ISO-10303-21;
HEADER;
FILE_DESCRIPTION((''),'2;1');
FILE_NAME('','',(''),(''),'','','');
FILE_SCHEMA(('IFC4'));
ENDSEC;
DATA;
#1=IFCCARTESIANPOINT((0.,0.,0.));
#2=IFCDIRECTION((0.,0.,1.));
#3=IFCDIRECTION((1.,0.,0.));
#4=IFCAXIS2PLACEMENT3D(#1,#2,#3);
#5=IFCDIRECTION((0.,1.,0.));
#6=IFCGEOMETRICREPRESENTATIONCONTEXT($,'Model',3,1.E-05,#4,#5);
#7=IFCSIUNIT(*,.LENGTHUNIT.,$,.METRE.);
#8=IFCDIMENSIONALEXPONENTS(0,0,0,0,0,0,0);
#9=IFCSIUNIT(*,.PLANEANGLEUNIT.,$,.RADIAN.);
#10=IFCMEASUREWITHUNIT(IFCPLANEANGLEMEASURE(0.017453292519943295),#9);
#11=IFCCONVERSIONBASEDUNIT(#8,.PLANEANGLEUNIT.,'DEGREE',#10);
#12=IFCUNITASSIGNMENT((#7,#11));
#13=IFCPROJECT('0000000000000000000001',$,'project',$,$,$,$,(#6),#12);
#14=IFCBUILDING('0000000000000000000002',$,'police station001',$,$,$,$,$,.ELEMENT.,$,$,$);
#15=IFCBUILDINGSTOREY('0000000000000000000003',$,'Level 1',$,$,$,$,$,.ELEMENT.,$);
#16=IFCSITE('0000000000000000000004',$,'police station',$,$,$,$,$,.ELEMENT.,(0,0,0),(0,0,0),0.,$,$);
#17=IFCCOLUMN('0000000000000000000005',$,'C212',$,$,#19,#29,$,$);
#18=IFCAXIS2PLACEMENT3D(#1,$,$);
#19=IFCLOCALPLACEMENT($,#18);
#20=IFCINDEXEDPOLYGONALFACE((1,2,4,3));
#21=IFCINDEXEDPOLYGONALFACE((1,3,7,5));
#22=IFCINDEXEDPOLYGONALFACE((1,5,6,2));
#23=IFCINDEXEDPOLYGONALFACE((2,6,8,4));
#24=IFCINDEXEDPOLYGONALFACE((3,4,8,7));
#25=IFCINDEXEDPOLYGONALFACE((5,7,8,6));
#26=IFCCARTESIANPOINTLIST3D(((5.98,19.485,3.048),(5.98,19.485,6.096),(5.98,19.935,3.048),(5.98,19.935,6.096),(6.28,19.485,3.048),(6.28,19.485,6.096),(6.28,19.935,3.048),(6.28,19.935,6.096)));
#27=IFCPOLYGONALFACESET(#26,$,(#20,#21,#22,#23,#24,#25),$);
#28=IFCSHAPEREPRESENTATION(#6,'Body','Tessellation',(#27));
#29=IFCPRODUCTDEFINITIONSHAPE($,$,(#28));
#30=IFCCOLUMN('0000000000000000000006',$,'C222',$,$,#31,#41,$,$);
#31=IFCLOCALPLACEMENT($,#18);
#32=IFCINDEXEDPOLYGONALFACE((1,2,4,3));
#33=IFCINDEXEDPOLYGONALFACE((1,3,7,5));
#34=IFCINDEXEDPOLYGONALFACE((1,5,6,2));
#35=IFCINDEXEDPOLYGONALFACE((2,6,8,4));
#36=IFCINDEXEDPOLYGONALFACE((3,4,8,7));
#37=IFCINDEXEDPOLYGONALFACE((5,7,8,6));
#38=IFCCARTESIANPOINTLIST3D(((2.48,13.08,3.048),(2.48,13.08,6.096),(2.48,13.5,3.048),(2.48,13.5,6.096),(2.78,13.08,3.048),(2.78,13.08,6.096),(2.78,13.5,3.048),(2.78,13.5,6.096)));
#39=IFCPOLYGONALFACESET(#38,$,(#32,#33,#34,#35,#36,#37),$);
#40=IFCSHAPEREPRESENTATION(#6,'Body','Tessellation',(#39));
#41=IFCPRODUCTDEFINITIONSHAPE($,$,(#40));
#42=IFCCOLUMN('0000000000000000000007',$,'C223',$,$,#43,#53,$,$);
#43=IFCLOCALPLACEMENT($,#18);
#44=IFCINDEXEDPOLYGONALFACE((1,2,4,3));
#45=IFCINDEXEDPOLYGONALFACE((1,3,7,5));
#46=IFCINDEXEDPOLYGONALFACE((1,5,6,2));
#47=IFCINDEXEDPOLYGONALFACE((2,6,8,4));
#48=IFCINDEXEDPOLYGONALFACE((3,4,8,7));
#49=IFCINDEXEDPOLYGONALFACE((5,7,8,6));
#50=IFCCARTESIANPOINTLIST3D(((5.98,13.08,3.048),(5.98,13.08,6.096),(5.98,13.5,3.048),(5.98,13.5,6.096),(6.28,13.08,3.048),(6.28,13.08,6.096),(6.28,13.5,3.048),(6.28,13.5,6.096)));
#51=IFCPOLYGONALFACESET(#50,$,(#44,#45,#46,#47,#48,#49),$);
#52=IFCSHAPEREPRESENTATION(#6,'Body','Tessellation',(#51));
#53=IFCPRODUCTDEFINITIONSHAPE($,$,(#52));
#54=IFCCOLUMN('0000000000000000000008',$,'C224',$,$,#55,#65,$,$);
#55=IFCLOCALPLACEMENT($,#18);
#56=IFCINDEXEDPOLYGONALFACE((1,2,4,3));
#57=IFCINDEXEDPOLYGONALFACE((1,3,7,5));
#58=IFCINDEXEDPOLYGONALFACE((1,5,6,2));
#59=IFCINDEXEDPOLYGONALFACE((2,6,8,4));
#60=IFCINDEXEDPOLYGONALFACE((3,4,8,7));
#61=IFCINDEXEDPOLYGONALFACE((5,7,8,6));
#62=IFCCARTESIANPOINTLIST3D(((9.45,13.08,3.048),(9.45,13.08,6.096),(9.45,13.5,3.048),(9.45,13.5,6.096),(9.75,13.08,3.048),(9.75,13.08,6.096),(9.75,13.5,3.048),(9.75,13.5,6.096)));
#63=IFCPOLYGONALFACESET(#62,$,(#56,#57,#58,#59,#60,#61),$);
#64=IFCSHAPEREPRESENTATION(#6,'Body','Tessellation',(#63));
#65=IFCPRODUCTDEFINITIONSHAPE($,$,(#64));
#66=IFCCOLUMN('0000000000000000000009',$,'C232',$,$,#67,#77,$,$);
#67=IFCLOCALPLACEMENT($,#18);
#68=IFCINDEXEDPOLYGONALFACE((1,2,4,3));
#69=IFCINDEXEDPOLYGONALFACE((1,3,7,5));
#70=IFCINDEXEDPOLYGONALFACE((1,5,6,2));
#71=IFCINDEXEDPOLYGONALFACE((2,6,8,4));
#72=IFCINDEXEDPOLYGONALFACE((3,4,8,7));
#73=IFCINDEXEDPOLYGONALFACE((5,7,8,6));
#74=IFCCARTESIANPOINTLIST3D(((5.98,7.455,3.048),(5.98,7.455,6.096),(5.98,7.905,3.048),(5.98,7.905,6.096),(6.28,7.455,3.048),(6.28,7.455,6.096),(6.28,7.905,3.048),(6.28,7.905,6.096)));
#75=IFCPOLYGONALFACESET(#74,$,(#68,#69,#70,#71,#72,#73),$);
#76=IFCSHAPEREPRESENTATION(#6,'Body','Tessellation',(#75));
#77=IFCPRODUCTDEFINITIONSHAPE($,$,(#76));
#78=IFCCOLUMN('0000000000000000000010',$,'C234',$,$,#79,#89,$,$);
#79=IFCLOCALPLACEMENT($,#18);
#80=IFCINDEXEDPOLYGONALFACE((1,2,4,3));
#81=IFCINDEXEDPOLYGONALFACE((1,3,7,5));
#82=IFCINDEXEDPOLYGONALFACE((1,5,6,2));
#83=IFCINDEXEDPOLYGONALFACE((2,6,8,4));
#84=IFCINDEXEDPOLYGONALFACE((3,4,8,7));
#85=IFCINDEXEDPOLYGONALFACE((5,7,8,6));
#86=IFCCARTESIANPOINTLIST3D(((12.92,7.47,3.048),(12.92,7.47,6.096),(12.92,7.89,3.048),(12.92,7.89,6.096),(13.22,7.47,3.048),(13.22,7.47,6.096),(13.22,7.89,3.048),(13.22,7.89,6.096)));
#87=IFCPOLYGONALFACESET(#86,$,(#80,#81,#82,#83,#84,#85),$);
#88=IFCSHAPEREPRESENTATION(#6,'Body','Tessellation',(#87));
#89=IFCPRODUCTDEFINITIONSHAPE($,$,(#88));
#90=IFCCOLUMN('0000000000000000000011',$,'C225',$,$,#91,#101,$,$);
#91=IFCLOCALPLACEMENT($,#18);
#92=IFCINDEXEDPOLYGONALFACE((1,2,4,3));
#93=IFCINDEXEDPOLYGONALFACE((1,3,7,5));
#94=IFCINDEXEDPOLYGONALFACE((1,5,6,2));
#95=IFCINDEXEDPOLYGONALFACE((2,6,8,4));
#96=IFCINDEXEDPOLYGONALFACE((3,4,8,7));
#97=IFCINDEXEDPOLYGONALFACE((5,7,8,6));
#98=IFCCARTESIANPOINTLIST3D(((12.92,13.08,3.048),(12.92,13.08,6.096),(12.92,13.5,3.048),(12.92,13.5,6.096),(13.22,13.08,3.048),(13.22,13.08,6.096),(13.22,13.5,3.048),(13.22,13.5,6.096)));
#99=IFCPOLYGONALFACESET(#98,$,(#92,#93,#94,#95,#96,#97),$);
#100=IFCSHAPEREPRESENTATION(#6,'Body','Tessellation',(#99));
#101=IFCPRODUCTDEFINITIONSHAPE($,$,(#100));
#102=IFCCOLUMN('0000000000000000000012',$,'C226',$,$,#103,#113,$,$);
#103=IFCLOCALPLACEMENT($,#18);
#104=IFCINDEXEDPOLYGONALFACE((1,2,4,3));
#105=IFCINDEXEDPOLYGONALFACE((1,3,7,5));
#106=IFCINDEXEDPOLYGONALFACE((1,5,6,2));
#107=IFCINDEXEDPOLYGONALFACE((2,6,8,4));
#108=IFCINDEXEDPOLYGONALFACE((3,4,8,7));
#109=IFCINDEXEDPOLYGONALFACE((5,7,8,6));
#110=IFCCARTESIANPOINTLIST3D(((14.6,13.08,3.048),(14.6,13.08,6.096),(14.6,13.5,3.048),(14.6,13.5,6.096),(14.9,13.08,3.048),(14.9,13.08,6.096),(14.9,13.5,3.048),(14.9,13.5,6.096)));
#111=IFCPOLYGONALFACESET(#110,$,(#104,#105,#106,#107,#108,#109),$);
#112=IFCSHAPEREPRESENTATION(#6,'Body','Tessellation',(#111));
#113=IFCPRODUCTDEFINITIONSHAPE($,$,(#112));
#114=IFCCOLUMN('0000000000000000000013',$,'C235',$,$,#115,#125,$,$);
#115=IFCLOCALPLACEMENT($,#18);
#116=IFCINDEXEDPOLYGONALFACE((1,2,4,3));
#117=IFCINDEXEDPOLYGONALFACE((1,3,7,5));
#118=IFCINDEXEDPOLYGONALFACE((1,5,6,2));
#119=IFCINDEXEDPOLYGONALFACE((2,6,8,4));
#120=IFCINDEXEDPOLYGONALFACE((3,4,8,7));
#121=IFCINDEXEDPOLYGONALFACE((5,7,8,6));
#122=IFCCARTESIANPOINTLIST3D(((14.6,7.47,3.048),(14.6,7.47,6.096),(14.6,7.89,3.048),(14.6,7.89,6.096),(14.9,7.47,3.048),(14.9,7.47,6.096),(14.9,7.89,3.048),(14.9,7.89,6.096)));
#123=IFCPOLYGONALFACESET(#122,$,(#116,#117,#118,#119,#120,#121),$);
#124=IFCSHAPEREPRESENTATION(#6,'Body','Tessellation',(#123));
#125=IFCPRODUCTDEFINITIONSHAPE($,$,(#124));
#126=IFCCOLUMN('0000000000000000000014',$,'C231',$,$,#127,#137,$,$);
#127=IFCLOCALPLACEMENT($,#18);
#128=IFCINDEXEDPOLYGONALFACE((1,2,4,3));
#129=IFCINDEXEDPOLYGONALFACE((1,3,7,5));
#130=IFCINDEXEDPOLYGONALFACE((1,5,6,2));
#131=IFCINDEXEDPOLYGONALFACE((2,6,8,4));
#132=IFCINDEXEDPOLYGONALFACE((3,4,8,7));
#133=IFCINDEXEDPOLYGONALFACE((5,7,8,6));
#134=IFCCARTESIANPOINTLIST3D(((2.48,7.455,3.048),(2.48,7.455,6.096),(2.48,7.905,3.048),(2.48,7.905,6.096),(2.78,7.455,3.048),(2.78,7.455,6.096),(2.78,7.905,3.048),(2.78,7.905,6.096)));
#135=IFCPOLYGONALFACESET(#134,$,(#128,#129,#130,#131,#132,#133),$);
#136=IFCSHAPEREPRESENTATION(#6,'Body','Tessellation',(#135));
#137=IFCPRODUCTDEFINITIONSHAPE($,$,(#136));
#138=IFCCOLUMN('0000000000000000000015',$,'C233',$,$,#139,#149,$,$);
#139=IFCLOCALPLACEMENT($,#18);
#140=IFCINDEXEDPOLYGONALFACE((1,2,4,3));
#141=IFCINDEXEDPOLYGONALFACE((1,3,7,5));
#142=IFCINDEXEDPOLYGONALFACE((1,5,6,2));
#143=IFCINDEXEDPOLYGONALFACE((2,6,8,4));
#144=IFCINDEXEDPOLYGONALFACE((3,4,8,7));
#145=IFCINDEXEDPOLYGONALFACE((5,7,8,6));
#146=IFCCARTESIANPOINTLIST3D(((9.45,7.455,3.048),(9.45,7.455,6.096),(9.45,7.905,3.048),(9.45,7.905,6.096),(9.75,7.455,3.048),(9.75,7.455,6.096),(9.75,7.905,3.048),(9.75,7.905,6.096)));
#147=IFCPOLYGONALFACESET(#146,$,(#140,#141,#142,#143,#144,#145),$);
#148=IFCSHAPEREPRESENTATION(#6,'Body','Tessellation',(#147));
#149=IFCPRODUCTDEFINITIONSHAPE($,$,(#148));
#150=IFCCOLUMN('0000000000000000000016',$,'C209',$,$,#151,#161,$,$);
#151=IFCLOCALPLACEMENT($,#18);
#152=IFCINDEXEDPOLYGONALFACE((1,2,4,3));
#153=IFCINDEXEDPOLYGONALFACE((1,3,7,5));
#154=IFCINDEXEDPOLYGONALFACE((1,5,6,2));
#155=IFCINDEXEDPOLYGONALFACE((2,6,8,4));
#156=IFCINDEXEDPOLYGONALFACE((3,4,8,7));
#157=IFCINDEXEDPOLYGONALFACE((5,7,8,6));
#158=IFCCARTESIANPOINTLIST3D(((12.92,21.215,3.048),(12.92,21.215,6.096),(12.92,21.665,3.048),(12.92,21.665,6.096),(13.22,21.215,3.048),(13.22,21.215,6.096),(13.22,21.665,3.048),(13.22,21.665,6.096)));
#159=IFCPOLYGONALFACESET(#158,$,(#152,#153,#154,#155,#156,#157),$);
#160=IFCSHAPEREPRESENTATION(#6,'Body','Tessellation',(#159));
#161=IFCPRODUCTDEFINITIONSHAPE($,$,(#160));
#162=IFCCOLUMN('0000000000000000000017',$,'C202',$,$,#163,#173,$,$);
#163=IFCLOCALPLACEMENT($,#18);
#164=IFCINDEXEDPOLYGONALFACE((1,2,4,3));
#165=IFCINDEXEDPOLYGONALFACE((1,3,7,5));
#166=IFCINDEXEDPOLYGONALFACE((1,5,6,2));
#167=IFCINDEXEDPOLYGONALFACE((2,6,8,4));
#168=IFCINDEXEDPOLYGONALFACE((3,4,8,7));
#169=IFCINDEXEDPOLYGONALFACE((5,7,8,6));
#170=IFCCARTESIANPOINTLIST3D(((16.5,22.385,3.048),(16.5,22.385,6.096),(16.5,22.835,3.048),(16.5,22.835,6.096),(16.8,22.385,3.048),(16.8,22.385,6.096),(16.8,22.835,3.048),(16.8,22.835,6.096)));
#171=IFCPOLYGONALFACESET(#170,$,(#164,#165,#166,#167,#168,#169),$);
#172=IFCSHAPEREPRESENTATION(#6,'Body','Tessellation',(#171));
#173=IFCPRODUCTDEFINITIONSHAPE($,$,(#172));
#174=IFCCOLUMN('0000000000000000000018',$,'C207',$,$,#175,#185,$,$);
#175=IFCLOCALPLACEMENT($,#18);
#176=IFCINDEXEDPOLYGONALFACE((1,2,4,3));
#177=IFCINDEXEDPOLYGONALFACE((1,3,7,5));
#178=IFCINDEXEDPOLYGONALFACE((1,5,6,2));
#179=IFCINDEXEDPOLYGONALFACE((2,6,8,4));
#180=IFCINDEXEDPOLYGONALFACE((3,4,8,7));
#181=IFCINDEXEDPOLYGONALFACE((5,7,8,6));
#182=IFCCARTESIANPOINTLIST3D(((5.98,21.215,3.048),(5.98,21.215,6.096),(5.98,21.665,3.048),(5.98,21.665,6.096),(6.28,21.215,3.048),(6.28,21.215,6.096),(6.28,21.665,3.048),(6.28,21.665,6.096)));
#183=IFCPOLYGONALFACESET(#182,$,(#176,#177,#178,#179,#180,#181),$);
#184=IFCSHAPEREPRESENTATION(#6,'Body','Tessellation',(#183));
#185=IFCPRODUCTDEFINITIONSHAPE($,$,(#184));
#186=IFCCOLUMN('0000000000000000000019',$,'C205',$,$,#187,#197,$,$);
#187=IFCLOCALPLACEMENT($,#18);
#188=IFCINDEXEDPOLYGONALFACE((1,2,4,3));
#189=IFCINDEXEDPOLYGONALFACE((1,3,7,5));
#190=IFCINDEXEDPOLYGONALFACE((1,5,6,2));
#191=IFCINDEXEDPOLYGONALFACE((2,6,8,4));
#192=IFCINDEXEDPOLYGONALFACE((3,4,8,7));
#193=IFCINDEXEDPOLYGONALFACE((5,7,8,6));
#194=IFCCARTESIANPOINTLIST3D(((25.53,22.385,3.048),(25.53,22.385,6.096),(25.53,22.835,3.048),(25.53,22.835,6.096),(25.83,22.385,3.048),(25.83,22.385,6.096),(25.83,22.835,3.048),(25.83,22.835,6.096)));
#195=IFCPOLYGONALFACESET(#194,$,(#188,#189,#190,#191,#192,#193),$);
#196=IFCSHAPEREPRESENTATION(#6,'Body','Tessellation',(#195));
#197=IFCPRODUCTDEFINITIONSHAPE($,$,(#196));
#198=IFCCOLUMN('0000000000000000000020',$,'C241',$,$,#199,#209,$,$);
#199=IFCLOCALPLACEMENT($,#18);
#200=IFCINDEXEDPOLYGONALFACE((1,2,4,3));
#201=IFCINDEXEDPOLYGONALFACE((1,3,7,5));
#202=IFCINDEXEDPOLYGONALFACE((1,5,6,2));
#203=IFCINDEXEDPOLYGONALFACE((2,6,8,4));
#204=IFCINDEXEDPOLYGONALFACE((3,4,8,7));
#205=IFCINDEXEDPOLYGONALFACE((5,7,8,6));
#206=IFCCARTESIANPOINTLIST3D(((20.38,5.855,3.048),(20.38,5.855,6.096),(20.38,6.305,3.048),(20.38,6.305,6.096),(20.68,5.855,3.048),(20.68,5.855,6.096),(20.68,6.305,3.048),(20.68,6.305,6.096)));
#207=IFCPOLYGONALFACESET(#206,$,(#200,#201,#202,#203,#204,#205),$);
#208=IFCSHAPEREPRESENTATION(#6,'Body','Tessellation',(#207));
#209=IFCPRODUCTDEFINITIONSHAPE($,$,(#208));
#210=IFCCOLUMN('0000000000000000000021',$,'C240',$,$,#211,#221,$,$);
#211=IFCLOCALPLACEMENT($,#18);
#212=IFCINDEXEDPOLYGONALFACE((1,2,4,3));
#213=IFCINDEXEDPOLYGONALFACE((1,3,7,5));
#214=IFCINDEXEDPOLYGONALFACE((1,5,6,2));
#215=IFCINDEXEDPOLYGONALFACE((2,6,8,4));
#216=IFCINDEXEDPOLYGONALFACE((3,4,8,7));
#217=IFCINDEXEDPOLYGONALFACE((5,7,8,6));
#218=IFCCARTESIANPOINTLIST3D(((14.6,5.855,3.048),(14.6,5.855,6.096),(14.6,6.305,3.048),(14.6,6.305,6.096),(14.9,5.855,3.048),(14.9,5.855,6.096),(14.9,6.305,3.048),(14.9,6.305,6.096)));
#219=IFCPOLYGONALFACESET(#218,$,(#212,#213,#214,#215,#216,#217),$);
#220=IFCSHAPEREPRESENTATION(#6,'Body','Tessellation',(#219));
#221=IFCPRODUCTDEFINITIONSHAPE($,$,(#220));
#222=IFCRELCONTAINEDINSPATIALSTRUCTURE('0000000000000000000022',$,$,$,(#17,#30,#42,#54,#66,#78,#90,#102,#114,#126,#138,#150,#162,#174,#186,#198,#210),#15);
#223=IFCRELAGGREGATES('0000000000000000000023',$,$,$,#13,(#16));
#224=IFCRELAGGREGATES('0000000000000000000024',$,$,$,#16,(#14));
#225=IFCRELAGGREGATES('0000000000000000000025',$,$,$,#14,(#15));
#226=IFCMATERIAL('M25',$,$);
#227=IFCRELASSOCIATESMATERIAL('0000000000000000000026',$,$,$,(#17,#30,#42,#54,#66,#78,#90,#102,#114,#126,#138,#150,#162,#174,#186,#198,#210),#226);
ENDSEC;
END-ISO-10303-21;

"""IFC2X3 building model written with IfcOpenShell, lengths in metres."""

from ifc_helpers import new_model, entity, si_unit, converted_unit, direction, frame, frame_2d, origin_with_axes, place, context, project, spatial, rectangle, extrude, material, element, save


model = new_model("IFC2X3")

# Units and contexts
model_context = context("Model", 3, precision=1e-05, world=origin_with_axes(), true_north=direction((0.0, 1.0, 0.0)))
ifc_project = project(units=[si_unit("LENGTHUNIT", "METRE"), converted_unit("PLANEANGLEUNIT", "DEGREE", entity("IfcPlaneAngleMeasure", 0.017453292519943295), si_unit("PLANEANGLEUNIT", "RADIAN"), dimensions=[0, 0, 0, 0, 0, 0, 0])], contexts=[model_context])

# Site, building, storey
site = spatial("IfcSite", under=ifc_project, Name="police station", CompositionType="ELEMENT", RefLatitude=(0, 0, 0), RefLongitude=(0, 0, 0), RefElevation=0.0)
building = spatial("IfcBuilding", under=site, Name="police station001", CompositionType="ELEMENT")
storey = spatial("IfcBuildingStorey", under=building, Name="Level 1", CompositionType="ELEMENT")

# Columns
ifc_material = material(Name="M25")
placement = place(None, origin_with_axes())
element("IfcColumn", 1, at=placement, inside=storey, material=ifc_material, Name="C212", context=model_context, shape_type="SweptSolid", body=[
    extrude(rectangle(XDim=0.3, YDim=0.45, at=frame_2d((0.0, 0.0), x_axis=(1.0, 0.0, 0.0))), frame((6.13, 19.71, 3.048), z_axis=(0.0, 0.0, 1.0), x_axis=(1.0, 0.0, 0.0)), (0.0, 0.0, 1.0), 3.048),
])
element("IfcColumn", 2, at=placement, inside=storey, material=ifc_material, Name="C222", context=model_context, shape_type="SweptSolid", body=[
    extrude(rectangle(XDim=0.3, YDim=0.42, at=frame_2d((0.0, 0.0), x_axis=(1.0, 0.0, 0.0))), frame((2.63, 13.29, 3.048), z_axis=(0.0, 0.0, 1.0), x_axis=(1.0, 0.0, 0.0)), (0.0, 0.0, 1.0), 3.048),
])
element("IfcColumn", 3, at=placement, inside=storey, material=ifc_material, Name="C223", context=model_context, shape_type="SweptSolid", body=[
    extrude(rectangle(XDim=0.3, YDim=0.42, at=frame_2d((0.0, 0.0), x_axis=(1.0, 0.0, 0.0))), frame((6.13, 13.29, 3.048), z_axis=(0.0, 0.0, 1.0), x_axis=(1.0, 0.0, 0.0)), (0.0, 0.0, 1.0), 3.048),
])
element("IfcColumn", 4, at=placement, inside=storey, material=ifc_material, Name="C224", context=model_context, shape_type="SweptSolid", body=[
    extrude(rectangle(XDim=0.3, YDim=0.42, at=frame_2d((0.0, 0.0), x_axis=(1.0, 0.0, 0.0))), frame((9.6, 13.29, 3.048), z_axis=(0.0, 0.0, 1.0), x_axis=(1.0, 0.0, 0.0)), (0.0, 0.0, 1.0), 3.048),
])
element("IfcColumn", 5, at=placement, inside=storey, material=ifc_material, Name="C232", context=model_context, shape_type="SweptSolid", body=[
    extrude(rectangle(XDim=0.3, YDim=0.45, at=frame_2d((0.0, 0.0), x_axis=(1.0, 0.0, 0.0))), frame((6.13, 7.68, 3.048), z_axis=(0.0, 0.0, 1.0), x_axis=(1.0, 0.0, 0.0)), (0.0, 0.0, 1.0), 3.048),
])
element("IfcColumn", 6, at=placement, inside=storey, material=ifc_material, Name="C234", context=model_context, shape_type="SweptSolid", body=[
    extrude(rectangle(XDim=0.3, YDim=0.42, at=frame_2d((0.0, 0.0), x_axis=(1.0, 0.0, 0.0))), frame((13.07, 7.68, 3.048), z_axis=(0.0, 0.0, 1.0), x_axis=(1.0, 0.0, 0.0)), (0.0, 0.0, 1.0), 3.048),
])
element("IfcColumn", 7, at=placement, inside=storey, material=ifc_material, Name="C225", context=model_context, shape_type="SweptSolid", body=[
    extrude(rectangle(XDim=0.3, YDim=0.42, at=frame_2d((0.0, 0.0), x_axis=(1.0, 0.0, 0.0))), frame((13.07, 13.29, 3.048), z_axis=(0.0, 0.0, 1.0), x_axis=(1.0, 0.0, 0.0)), (0.0, 0.0, 1.0), 3.048),
])
element("IfcColumn", 8, at=placement, inside=storey, material=ifc_material, Name="C226", context=model_context, shape_type="SweptSolid", body=[
    extrude(rectangle(XDim=0.3, YDim=0.42, at=frame_2d((0.0, 0.0), x_axis=(1.0, 0.0, 0.0))), frame((14.75, 13.29, 3.048), z_axis=(0.0, 0.0, 1.0), x_axis=(1.0, 0.0, 0.0)), (0.0, 0.0, 1.0), 3.048),
])
element("IfcColumn", 9, at=placement, inside=storey, material=ifc_material, Name="C235", context=model_context, shape_type="SweptSolid", body=[
    extrude(rectangle(XDim=0.3, YDim=0.42, at=frame_2d((0.0, 0.0), x_axis=(1.0, 0.0, 0.0))), frame((14.75, 7.68, 3.048), z_axis=(0.0, 0.0, 1.0), x_axis=(1.0, 0.0, 0.0)), (0.0, 0.0, 1.0), 3.048),
])
element("IfcColumn", 10, at=placement, inside=storey, material=ifc_material, Name="C231", context=model_context, shape_type="SweptSolid", body=[
    extrude(rectangle(XDim=0.3, YDim=0.45, at=frame_2d((0.0, 0.0), x_axis=(1.0, 0.0, 0.0))), frame((2.63, 7.68, 3.048), z_axis=(0.0, 0.0, 1.0), x_axis=(1.0, 0.0, 0.0)), (0.0, 0.0, 1.0), 3.048),
])
element("IfcColumn", 11, at=placement, inside=storey, material=ifc_material, Name="C233", context=model_context, shape_type="SweptSolid", body=[
    extrude(rectangle(XDim=0.3, YDim=0.45, at=frame_2d((0.0, 0.0), x_axis=(1.0, 0.0, 0.0))), frame((9.6, 7.68, 3.048), z_axis=(0.0, 0.0, 1.0), x_axis=(1.0, 0.0, 0.0)), (0.0, 0.0, 1.0), 3.048),
])
element("IfcColumn", 12, at=placement, inside=storey, material=ifc_material, Name="C209", context=model_context, shape_type="SweptSolid", body=[
    extrude(rectangle(XDim=0.3, YDim=0.45, at=frame_2d((0.0, 0.0), x_axis=(1.0, 0.0, 0.0))), frame((13.07, 21.44, 3.048), z_axis=(0.0, 0.0, 1.0), x_axis=(1.0, 0.0, 0.0)), (0.0, 0.0, 1.0), 3.048),
])
element("IfcColumn", 13, at=placement, inside=storey, material=ifc_material, Name="C202", context=model_context, shape_type="SweptSolid", body=[
    extrude(rectangle(XDim=0.3, YDim=0.45, at=frame_2d((0.0, 0.0), x_axis=(1.0, 0.0, 0.0))), frame((16.65, 22.61, 3.048), z_axis=(0.0, 0.0, 1.0), x_axis=(1.0, 0.0, 0.0)), (0.0, 0.0, 1.0), 3.048),
])
element("IfcColumn", 14, at=placement, inside=storey, material=ifc_material, Name="C207", context=model_context, shape_type="SweptSolid", body=[
    extrude(rectangle(XDim=0.3, YDim=0.45, at=frame_2d((0.0, 0.0), x_axis=(1.0, 0.0, 0.0))), frame((6.13, 21.44, 3.048), z_axis=(0.0, 0.0, 1.0), x_axis=(1.0, 0.0, 0.0)), (0.0, 0.0, 1.0), 3.048),
])
element("IfcColumn", 15, at=placement, inside=storey, material=ifc_material, Name="C205", context=model_context, shape_type="SweptSolid", body=[
    extrude(rectangle(XDim=0.3, YDim=0.45, at=frame_2d((0.0, 0.0), x_axis=(1.0, 0.0, 0.0))), frame((25.68, 22.61, 3.048), z_axis=(0.0, 0.0, 1.0), x_axis=(1.0, 0.0, 0.0)), (0.0, 0.0, 1.0), 3.048),
])
element("IfcColumn", 16, at=placement, inside=storey, material=ifc_material, Name="C241", context=model_context, shape_type="SweptSolid", body=[
    extrude(rectangle(XDim=0.3, YDim=0.45, at=frame_2d((0.0, 0.0), x_axis=(1.0, 0.0, 0.0))), frame((20.53, 6.08, 3.048), z_axis=(0.0, 0.0, 1.0), x_axis=(1.0, 0.0, 0.0)), (0.0, 0.0, 1.0), 3.048),
])
element("IfcColumn", 17, at=placement, inside=storey, material=ifc_material, Name="C240", context=model_context, shape_type="SweptSolid", body=[
    extrude(rectangle(XDim=0.3, YDim=0.45, at=frame_2d((0.0, 0.0), x_axis=(1.0, 0.0, 0.0))), frame((14.75, 6.08, 3.048), z_axis=(0.0, 0.0, 1.0), x_axis=(1.0, 0.0, 0.0)), (0.0, 0.0, 1.0), 3.048),
])

save(model, "model.ifc")
